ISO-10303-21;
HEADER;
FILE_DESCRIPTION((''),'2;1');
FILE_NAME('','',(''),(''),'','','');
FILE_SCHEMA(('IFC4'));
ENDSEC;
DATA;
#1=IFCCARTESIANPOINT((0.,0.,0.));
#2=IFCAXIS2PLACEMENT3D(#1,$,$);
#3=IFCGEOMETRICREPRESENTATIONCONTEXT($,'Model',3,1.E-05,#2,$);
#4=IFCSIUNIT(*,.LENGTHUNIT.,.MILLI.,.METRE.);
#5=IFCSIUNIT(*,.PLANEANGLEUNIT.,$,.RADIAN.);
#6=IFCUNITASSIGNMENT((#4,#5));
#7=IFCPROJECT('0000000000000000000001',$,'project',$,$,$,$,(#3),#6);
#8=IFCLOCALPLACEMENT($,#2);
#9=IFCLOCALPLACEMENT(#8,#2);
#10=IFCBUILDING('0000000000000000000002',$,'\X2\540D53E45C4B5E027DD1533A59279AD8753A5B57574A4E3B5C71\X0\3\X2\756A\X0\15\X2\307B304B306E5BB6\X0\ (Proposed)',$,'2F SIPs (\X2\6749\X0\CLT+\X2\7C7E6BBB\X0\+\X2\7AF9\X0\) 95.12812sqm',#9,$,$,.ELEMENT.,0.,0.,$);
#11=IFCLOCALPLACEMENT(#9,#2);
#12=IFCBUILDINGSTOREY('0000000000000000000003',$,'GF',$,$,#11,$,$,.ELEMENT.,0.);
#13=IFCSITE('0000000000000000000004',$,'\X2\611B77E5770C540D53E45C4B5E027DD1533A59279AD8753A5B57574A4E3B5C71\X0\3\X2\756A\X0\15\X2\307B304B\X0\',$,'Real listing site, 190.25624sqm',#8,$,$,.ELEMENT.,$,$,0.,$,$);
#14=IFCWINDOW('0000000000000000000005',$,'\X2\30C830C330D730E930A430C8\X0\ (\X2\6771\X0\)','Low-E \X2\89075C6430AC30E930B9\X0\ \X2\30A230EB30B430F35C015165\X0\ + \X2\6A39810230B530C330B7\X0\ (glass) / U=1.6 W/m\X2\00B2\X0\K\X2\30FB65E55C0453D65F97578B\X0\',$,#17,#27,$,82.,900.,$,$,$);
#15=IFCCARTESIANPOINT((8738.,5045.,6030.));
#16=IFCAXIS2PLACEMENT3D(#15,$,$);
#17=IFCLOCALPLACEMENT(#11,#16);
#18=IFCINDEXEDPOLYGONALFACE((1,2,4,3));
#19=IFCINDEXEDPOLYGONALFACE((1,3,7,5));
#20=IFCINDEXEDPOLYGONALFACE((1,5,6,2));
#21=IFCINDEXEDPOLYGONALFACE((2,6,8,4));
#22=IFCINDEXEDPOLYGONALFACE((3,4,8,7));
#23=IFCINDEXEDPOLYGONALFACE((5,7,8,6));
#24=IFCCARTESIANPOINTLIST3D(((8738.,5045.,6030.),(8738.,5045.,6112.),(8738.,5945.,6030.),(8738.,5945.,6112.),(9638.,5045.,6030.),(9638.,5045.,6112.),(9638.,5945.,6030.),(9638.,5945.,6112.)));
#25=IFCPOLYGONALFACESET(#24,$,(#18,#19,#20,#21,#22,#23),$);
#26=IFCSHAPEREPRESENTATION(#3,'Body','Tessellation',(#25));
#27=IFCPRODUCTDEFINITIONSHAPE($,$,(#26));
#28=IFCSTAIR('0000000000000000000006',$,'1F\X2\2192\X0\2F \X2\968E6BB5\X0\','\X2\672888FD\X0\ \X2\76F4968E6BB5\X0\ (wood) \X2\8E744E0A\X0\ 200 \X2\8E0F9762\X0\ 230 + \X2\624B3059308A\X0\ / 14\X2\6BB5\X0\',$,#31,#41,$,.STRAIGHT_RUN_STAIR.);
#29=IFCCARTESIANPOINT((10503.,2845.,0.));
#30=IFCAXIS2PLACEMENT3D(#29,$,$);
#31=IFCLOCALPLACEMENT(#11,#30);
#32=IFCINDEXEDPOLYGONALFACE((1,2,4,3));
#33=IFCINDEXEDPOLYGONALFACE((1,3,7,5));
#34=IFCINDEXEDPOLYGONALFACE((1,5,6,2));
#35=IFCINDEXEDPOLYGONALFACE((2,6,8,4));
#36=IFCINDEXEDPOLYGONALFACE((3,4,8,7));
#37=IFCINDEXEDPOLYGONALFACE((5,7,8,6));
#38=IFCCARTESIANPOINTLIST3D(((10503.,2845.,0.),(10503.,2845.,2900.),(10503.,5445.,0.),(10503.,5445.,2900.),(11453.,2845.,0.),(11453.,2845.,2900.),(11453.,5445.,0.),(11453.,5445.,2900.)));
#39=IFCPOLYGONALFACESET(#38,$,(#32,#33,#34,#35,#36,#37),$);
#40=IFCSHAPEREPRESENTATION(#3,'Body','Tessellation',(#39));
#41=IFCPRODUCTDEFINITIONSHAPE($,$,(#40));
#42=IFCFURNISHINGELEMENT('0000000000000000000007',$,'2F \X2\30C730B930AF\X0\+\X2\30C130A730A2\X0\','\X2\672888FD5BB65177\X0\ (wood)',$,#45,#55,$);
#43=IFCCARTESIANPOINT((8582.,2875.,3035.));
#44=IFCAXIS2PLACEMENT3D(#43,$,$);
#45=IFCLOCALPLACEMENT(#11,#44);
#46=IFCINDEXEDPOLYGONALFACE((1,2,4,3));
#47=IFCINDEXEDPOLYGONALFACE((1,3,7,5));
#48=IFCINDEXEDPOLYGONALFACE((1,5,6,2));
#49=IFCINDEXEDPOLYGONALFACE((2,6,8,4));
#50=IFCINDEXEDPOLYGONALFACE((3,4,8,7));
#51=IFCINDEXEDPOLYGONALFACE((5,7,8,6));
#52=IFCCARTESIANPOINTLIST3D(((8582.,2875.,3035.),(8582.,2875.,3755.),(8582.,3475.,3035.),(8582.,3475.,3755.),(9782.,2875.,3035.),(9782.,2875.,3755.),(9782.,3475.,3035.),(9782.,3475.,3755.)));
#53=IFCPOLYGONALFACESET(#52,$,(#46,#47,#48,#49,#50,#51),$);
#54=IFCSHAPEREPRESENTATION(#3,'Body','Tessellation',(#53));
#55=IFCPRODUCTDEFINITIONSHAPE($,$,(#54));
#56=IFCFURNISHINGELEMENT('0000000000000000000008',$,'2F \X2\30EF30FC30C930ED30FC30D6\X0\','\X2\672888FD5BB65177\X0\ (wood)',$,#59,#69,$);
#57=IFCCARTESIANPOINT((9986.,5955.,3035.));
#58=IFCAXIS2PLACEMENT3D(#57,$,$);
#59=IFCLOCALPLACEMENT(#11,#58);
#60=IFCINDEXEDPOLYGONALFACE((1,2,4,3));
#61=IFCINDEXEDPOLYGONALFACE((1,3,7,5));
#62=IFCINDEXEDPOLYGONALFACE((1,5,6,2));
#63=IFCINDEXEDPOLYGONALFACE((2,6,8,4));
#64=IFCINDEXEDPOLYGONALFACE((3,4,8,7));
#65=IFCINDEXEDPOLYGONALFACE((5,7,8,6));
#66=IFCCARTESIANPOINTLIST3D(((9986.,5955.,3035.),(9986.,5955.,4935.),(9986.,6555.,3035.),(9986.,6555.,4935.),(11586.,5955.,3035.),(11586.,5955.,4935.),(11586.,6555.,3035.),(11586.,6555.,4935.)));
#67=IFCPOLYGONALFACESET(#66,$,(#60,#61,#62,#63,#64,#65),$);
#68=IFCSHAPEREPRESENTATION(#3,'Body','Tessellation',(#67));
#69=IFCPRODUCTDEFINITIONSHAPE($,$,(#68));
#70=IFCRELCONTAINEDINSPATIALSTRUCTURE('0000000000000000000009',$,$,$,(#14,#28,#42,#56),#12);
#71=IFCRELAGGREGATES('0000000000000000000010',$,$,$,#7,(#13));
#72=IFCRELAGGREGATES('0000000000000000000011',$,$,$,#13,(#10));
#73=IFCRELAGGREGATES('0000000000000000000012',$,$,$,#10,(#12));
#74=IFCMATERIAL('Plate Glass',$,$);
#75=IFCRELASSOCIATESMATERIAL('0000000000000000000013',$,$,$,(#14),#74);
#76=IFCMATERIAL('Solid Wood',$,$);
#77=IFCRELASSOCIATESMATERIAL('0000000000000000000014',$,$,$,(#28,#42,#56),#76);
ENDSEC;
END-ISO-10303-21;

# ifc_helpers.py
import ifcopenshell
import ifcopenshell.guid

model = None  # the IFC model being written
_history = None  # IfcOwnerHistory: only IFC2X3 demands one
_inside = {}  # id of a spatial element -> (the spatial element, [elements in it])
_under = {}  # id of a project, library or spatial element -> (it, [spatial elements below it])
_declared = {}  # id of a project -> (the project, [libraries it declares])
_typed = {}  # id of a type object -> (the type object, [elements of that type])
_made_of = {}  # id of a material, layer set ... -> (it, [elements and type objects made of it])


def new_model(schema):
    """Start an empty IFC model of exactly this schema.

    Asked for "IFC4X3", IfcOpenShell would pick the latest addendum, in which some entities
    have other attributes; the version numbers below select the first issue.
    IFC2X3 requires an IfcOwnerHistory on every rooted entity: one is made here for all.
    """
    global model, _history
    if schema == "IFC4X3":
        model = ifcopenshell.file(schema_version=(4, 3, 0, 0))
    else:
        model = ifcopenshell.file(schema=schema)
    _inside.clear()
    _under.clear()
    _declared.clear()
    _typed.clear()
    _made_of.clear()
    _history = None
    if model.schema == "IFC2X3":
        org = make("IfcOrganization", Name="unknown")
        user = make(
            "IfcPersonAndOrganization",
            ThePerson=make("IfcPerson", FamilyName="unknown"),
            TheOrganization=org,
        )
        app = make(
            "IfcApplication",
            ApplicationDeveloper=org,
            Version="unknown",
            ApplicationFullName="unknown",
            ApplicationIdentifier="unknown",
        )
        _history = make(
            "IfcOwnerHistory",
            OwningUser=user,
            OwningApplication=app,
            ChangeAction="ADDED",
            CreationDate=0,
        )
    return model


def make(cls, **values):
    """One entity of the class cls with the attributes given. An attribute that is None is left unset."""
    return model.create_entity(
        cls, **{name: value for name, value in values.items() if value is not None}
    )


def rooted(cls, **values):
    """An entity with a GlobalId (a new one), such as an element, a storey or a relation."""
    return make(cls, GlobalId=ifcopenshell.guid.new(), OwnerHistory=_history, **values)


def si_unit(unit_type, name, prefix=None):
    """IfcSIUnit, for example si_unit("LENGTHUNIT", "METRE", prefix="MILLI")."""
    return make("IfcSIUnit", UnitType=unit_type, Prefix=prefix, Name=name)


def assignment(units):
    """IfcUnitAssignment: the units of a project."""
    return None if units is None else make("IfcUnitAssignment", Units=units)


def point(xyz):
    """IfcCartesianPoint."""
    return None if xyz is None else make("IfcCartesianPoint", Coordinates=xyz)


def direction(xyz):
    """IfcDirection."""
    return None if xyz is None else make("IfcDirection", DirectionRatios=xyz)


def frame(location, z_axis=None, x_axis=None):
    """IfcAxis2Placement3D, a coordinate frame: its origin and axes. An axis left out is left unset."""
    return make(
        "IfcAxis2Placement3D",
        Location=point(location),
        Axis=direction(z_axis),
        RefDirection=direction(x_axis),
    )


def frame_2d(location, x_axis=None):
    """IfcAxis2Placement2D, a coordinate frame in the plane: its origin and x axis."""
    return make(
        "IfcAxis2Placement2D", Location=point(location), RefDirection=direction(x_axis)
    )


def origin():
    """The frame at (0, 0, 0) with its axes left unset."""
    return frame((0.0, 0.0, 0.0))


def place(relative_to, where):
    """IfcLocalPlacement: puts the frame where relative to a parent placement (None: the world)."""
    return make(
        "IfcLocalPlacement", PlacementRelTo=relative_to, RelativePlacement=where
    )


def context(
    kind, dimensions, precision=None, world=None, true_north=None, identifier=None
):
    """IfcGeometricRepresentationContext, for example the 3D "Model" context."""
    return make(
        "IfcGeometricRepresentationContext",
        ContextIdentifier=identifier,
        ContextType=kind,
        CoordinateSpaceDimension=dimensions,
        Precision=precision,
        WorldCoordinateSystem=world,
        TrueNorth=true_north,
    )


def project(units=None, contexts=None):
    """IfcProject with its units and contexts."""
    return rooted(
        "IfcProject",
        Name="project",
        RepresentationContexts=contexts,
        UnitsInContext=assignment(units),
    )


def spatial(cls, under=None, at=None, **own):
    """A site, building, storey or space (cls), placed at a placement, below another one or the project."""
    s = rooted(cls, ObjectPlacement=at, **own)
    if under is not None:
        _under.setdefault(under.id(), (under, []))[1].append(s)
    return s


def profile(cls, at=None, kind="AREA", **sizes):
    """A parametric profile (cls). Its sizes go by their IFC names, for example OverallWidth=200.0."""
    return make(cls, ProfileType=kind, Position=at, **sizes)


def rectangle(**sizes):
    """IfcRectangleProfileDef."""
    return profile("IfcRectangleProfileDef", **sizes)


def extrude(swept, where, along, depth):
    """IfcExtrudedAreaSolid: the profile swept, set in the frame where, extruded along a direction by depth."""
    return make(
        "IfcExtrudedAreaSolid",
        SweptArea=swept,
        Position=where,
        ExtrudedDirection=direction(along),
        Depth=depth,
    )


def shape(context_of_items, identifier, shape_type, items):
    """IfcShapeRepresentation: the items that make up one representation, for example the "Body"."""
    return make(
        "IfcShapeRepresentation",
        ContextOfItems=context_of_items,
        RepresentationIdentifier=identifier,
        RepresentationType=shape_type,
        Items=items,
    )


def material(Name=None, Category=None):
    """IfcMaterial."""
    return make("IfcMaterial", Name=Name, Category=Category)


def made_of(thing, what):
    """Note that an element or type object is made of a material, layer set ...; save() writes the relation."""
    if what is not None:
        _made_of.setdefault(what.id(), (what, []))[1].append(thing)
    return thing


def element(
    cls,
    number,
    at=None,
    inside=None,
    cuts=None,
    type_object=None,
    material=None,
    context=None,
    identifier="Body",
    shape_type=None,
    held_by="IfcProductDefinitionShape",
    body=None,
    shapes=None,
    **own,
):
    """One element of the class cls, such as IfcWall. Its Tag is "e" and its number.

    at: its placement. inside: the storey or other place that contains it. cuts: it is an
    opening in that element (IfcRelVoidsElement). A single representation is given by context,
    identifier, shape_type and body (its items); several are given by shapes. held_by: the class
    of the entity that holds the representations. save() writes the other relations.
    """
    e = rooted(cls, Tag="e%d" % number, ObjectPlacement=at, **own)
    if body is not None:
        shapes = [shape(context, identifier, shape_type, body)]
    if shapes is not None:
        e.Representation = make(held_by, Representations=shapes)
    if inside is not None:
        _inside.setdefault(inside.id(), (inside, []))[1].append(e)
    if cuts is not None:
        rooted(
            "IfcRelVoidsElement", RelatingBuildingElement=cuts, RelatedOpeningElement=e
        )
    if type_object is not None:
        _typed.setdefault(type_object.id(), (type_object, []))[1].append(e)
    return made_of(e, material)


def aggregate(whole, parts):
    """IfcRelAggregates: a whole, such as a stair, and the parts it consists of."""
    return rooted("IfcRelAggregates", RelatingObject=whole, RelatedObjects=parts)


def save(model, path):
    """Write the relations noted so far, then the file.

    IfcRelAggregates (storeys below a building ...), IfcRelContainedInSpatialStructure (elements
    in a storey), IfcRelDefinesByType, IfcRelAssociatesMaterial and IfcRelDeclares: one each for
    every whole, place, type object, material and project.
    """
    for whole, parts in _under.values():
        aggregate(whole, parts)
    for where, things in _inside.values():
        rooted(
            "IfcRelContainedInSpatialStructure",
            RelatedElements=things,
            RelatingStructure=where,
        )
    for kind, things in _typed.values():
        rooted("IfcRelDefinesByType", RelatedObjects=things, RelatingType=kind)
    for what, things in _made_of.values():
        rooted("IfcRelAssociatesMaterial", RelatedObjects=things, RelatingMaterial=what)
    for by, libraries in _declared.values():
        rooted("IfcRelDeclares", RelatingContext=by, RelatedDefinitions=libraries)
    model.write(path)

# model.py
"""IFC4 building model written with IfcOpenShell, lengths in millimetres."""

from ifc_helpers import new_model, si_unit, frame, frame_2d, origin, place, context, project, spatial, rectangle, extrude, material, element, save


model = new_model("IFC4")

# Units and contexts
model_context = context("Model", 3, precision=1e-05, world=origin())
ifc_project = project(units=[si_unit("LENGTHUNIT", "METRE", prefix="MILLI"), si_unit("PLANEANGLEUNIT", "RADIAN")], contexts=[model_context])

# Site, building, storey
site_placement = place(None, origin())
site = spatial("IfcSite", under=ifc_project, at=site_placement, Name="愛知県名古屋市緑区大高町字坊主山3番15ほか", ObjectType="Real listing site, 190.25624sqm", CompositionType="ELEMENT", RefElevation=0.0)
building_placement = place(site_placement, origin())
building = spatial("IfcBuilding", under=site, at=building_placement, Name="名古屋市緑区大高町字坊主山3番15ほかの家 (Proposed)", ObjectType="2F SIPs (杉CLT+籾殻+竹) 95.12812sqm", CompositionType="ELEMENT", ElevationOfRefHeight=0.0, ElevationOfTerrain=0.0)
storey_placement = place(building_placement, origin())
storey = spatial("IfcBuildingStorey", under=building, at=storey_placement, Name="GF", CompositionType="ELEMENT", Elevation=0.0)

# Shared definitions
ifc_material_1 = material(Name="Solid Wood")

# Shared definitions
ifc_material_2 = material(Name="Plate Glass")

# Window
window_1_placement = place(storey_placement, frame((8738.0, 5045.0, 6030.0)))
element("IfcWindow", 1, at=window_1_placement, inside=storey, material=ifc_material_2, Name="トップライト (東)", Description="Low-E 複層ガラス アルゴン封入 + 樹脂サッシ (glass) / U=1.6 W/m²K・日射取得型", OverallHeight=82.0, OverallWidth=900.0, context=model_context, shape_type="SweptSolid", body=[
    extrude(rectangle(XDim=900.0, YDim=900.0, at=frame_2d((450.0, 450.0))), frame((8738.0, 5045.0, 6030.0)), (0.0, 0.0, 1.0), 82.0),
])

# Stair
stair_placement = place(storey_placement, frame((10503.0, 2845.0, 0.0)))
element("IfcStair", 2, at=stair_placement, inside=storey, material=ifc_material_1, Name="1F→2F 階段", Description="木製 直階段 (wood) 蹴上 200 踏面 230 + 手すり / 14段", PredefinedType="STRAIGHT_RUN_STAIR", context=model_context, shape_type="SweptSolid", body=[
    extrude(rectangle(XDim=950.0, YDim=2600.0, at=frame_2d((475.0, 1300.0))), frame((10503.0, 2845.0, 0.0)), (0.0, 0.0, 1.0), 2900.0),
])

# Furnishing elements
furnishing_1_placement = place(storey_placement, frame((8582.0, 2875.0, 3035.0)))
element("IfcFurnishingElement", 3, at=furnishing_1_placement, inside=storey, material=ifc_material_1, Name="2F デスク+チェア", Description="木製家具 (wood)", context=model_context, shape_type="SweptSolid", body=[
    extrude(rectangle(XDim=1200.0, YDim=600.0, at=frame_2d((600.0, 300.0))), frame((8582.0, 2875.0, 3035.0)), (0.0, 0.0, 1.0), 720.0),
])
furnishing_2_placement = place(storey_placement, frame((9986.0, 5955.0, 3035.0)))
element("IfcFurnishingElement", 4, at=furnishing_2_placement, inside=storey, material=ifc_material_1, Name="2F ワードローブ", Description="木製家具 (wood)", context=model_context, shape_type="SweptSolid", body=[
    extrude(rectangle(XDim=1600.0, YDim=600.0, at=frame_2d((800.0, 300.0))), frame((9986.0, 5955.0, 3035.0)), (0.0, 0.0, 1.0), 1900.0),
])

save(model, "model.ifc")
